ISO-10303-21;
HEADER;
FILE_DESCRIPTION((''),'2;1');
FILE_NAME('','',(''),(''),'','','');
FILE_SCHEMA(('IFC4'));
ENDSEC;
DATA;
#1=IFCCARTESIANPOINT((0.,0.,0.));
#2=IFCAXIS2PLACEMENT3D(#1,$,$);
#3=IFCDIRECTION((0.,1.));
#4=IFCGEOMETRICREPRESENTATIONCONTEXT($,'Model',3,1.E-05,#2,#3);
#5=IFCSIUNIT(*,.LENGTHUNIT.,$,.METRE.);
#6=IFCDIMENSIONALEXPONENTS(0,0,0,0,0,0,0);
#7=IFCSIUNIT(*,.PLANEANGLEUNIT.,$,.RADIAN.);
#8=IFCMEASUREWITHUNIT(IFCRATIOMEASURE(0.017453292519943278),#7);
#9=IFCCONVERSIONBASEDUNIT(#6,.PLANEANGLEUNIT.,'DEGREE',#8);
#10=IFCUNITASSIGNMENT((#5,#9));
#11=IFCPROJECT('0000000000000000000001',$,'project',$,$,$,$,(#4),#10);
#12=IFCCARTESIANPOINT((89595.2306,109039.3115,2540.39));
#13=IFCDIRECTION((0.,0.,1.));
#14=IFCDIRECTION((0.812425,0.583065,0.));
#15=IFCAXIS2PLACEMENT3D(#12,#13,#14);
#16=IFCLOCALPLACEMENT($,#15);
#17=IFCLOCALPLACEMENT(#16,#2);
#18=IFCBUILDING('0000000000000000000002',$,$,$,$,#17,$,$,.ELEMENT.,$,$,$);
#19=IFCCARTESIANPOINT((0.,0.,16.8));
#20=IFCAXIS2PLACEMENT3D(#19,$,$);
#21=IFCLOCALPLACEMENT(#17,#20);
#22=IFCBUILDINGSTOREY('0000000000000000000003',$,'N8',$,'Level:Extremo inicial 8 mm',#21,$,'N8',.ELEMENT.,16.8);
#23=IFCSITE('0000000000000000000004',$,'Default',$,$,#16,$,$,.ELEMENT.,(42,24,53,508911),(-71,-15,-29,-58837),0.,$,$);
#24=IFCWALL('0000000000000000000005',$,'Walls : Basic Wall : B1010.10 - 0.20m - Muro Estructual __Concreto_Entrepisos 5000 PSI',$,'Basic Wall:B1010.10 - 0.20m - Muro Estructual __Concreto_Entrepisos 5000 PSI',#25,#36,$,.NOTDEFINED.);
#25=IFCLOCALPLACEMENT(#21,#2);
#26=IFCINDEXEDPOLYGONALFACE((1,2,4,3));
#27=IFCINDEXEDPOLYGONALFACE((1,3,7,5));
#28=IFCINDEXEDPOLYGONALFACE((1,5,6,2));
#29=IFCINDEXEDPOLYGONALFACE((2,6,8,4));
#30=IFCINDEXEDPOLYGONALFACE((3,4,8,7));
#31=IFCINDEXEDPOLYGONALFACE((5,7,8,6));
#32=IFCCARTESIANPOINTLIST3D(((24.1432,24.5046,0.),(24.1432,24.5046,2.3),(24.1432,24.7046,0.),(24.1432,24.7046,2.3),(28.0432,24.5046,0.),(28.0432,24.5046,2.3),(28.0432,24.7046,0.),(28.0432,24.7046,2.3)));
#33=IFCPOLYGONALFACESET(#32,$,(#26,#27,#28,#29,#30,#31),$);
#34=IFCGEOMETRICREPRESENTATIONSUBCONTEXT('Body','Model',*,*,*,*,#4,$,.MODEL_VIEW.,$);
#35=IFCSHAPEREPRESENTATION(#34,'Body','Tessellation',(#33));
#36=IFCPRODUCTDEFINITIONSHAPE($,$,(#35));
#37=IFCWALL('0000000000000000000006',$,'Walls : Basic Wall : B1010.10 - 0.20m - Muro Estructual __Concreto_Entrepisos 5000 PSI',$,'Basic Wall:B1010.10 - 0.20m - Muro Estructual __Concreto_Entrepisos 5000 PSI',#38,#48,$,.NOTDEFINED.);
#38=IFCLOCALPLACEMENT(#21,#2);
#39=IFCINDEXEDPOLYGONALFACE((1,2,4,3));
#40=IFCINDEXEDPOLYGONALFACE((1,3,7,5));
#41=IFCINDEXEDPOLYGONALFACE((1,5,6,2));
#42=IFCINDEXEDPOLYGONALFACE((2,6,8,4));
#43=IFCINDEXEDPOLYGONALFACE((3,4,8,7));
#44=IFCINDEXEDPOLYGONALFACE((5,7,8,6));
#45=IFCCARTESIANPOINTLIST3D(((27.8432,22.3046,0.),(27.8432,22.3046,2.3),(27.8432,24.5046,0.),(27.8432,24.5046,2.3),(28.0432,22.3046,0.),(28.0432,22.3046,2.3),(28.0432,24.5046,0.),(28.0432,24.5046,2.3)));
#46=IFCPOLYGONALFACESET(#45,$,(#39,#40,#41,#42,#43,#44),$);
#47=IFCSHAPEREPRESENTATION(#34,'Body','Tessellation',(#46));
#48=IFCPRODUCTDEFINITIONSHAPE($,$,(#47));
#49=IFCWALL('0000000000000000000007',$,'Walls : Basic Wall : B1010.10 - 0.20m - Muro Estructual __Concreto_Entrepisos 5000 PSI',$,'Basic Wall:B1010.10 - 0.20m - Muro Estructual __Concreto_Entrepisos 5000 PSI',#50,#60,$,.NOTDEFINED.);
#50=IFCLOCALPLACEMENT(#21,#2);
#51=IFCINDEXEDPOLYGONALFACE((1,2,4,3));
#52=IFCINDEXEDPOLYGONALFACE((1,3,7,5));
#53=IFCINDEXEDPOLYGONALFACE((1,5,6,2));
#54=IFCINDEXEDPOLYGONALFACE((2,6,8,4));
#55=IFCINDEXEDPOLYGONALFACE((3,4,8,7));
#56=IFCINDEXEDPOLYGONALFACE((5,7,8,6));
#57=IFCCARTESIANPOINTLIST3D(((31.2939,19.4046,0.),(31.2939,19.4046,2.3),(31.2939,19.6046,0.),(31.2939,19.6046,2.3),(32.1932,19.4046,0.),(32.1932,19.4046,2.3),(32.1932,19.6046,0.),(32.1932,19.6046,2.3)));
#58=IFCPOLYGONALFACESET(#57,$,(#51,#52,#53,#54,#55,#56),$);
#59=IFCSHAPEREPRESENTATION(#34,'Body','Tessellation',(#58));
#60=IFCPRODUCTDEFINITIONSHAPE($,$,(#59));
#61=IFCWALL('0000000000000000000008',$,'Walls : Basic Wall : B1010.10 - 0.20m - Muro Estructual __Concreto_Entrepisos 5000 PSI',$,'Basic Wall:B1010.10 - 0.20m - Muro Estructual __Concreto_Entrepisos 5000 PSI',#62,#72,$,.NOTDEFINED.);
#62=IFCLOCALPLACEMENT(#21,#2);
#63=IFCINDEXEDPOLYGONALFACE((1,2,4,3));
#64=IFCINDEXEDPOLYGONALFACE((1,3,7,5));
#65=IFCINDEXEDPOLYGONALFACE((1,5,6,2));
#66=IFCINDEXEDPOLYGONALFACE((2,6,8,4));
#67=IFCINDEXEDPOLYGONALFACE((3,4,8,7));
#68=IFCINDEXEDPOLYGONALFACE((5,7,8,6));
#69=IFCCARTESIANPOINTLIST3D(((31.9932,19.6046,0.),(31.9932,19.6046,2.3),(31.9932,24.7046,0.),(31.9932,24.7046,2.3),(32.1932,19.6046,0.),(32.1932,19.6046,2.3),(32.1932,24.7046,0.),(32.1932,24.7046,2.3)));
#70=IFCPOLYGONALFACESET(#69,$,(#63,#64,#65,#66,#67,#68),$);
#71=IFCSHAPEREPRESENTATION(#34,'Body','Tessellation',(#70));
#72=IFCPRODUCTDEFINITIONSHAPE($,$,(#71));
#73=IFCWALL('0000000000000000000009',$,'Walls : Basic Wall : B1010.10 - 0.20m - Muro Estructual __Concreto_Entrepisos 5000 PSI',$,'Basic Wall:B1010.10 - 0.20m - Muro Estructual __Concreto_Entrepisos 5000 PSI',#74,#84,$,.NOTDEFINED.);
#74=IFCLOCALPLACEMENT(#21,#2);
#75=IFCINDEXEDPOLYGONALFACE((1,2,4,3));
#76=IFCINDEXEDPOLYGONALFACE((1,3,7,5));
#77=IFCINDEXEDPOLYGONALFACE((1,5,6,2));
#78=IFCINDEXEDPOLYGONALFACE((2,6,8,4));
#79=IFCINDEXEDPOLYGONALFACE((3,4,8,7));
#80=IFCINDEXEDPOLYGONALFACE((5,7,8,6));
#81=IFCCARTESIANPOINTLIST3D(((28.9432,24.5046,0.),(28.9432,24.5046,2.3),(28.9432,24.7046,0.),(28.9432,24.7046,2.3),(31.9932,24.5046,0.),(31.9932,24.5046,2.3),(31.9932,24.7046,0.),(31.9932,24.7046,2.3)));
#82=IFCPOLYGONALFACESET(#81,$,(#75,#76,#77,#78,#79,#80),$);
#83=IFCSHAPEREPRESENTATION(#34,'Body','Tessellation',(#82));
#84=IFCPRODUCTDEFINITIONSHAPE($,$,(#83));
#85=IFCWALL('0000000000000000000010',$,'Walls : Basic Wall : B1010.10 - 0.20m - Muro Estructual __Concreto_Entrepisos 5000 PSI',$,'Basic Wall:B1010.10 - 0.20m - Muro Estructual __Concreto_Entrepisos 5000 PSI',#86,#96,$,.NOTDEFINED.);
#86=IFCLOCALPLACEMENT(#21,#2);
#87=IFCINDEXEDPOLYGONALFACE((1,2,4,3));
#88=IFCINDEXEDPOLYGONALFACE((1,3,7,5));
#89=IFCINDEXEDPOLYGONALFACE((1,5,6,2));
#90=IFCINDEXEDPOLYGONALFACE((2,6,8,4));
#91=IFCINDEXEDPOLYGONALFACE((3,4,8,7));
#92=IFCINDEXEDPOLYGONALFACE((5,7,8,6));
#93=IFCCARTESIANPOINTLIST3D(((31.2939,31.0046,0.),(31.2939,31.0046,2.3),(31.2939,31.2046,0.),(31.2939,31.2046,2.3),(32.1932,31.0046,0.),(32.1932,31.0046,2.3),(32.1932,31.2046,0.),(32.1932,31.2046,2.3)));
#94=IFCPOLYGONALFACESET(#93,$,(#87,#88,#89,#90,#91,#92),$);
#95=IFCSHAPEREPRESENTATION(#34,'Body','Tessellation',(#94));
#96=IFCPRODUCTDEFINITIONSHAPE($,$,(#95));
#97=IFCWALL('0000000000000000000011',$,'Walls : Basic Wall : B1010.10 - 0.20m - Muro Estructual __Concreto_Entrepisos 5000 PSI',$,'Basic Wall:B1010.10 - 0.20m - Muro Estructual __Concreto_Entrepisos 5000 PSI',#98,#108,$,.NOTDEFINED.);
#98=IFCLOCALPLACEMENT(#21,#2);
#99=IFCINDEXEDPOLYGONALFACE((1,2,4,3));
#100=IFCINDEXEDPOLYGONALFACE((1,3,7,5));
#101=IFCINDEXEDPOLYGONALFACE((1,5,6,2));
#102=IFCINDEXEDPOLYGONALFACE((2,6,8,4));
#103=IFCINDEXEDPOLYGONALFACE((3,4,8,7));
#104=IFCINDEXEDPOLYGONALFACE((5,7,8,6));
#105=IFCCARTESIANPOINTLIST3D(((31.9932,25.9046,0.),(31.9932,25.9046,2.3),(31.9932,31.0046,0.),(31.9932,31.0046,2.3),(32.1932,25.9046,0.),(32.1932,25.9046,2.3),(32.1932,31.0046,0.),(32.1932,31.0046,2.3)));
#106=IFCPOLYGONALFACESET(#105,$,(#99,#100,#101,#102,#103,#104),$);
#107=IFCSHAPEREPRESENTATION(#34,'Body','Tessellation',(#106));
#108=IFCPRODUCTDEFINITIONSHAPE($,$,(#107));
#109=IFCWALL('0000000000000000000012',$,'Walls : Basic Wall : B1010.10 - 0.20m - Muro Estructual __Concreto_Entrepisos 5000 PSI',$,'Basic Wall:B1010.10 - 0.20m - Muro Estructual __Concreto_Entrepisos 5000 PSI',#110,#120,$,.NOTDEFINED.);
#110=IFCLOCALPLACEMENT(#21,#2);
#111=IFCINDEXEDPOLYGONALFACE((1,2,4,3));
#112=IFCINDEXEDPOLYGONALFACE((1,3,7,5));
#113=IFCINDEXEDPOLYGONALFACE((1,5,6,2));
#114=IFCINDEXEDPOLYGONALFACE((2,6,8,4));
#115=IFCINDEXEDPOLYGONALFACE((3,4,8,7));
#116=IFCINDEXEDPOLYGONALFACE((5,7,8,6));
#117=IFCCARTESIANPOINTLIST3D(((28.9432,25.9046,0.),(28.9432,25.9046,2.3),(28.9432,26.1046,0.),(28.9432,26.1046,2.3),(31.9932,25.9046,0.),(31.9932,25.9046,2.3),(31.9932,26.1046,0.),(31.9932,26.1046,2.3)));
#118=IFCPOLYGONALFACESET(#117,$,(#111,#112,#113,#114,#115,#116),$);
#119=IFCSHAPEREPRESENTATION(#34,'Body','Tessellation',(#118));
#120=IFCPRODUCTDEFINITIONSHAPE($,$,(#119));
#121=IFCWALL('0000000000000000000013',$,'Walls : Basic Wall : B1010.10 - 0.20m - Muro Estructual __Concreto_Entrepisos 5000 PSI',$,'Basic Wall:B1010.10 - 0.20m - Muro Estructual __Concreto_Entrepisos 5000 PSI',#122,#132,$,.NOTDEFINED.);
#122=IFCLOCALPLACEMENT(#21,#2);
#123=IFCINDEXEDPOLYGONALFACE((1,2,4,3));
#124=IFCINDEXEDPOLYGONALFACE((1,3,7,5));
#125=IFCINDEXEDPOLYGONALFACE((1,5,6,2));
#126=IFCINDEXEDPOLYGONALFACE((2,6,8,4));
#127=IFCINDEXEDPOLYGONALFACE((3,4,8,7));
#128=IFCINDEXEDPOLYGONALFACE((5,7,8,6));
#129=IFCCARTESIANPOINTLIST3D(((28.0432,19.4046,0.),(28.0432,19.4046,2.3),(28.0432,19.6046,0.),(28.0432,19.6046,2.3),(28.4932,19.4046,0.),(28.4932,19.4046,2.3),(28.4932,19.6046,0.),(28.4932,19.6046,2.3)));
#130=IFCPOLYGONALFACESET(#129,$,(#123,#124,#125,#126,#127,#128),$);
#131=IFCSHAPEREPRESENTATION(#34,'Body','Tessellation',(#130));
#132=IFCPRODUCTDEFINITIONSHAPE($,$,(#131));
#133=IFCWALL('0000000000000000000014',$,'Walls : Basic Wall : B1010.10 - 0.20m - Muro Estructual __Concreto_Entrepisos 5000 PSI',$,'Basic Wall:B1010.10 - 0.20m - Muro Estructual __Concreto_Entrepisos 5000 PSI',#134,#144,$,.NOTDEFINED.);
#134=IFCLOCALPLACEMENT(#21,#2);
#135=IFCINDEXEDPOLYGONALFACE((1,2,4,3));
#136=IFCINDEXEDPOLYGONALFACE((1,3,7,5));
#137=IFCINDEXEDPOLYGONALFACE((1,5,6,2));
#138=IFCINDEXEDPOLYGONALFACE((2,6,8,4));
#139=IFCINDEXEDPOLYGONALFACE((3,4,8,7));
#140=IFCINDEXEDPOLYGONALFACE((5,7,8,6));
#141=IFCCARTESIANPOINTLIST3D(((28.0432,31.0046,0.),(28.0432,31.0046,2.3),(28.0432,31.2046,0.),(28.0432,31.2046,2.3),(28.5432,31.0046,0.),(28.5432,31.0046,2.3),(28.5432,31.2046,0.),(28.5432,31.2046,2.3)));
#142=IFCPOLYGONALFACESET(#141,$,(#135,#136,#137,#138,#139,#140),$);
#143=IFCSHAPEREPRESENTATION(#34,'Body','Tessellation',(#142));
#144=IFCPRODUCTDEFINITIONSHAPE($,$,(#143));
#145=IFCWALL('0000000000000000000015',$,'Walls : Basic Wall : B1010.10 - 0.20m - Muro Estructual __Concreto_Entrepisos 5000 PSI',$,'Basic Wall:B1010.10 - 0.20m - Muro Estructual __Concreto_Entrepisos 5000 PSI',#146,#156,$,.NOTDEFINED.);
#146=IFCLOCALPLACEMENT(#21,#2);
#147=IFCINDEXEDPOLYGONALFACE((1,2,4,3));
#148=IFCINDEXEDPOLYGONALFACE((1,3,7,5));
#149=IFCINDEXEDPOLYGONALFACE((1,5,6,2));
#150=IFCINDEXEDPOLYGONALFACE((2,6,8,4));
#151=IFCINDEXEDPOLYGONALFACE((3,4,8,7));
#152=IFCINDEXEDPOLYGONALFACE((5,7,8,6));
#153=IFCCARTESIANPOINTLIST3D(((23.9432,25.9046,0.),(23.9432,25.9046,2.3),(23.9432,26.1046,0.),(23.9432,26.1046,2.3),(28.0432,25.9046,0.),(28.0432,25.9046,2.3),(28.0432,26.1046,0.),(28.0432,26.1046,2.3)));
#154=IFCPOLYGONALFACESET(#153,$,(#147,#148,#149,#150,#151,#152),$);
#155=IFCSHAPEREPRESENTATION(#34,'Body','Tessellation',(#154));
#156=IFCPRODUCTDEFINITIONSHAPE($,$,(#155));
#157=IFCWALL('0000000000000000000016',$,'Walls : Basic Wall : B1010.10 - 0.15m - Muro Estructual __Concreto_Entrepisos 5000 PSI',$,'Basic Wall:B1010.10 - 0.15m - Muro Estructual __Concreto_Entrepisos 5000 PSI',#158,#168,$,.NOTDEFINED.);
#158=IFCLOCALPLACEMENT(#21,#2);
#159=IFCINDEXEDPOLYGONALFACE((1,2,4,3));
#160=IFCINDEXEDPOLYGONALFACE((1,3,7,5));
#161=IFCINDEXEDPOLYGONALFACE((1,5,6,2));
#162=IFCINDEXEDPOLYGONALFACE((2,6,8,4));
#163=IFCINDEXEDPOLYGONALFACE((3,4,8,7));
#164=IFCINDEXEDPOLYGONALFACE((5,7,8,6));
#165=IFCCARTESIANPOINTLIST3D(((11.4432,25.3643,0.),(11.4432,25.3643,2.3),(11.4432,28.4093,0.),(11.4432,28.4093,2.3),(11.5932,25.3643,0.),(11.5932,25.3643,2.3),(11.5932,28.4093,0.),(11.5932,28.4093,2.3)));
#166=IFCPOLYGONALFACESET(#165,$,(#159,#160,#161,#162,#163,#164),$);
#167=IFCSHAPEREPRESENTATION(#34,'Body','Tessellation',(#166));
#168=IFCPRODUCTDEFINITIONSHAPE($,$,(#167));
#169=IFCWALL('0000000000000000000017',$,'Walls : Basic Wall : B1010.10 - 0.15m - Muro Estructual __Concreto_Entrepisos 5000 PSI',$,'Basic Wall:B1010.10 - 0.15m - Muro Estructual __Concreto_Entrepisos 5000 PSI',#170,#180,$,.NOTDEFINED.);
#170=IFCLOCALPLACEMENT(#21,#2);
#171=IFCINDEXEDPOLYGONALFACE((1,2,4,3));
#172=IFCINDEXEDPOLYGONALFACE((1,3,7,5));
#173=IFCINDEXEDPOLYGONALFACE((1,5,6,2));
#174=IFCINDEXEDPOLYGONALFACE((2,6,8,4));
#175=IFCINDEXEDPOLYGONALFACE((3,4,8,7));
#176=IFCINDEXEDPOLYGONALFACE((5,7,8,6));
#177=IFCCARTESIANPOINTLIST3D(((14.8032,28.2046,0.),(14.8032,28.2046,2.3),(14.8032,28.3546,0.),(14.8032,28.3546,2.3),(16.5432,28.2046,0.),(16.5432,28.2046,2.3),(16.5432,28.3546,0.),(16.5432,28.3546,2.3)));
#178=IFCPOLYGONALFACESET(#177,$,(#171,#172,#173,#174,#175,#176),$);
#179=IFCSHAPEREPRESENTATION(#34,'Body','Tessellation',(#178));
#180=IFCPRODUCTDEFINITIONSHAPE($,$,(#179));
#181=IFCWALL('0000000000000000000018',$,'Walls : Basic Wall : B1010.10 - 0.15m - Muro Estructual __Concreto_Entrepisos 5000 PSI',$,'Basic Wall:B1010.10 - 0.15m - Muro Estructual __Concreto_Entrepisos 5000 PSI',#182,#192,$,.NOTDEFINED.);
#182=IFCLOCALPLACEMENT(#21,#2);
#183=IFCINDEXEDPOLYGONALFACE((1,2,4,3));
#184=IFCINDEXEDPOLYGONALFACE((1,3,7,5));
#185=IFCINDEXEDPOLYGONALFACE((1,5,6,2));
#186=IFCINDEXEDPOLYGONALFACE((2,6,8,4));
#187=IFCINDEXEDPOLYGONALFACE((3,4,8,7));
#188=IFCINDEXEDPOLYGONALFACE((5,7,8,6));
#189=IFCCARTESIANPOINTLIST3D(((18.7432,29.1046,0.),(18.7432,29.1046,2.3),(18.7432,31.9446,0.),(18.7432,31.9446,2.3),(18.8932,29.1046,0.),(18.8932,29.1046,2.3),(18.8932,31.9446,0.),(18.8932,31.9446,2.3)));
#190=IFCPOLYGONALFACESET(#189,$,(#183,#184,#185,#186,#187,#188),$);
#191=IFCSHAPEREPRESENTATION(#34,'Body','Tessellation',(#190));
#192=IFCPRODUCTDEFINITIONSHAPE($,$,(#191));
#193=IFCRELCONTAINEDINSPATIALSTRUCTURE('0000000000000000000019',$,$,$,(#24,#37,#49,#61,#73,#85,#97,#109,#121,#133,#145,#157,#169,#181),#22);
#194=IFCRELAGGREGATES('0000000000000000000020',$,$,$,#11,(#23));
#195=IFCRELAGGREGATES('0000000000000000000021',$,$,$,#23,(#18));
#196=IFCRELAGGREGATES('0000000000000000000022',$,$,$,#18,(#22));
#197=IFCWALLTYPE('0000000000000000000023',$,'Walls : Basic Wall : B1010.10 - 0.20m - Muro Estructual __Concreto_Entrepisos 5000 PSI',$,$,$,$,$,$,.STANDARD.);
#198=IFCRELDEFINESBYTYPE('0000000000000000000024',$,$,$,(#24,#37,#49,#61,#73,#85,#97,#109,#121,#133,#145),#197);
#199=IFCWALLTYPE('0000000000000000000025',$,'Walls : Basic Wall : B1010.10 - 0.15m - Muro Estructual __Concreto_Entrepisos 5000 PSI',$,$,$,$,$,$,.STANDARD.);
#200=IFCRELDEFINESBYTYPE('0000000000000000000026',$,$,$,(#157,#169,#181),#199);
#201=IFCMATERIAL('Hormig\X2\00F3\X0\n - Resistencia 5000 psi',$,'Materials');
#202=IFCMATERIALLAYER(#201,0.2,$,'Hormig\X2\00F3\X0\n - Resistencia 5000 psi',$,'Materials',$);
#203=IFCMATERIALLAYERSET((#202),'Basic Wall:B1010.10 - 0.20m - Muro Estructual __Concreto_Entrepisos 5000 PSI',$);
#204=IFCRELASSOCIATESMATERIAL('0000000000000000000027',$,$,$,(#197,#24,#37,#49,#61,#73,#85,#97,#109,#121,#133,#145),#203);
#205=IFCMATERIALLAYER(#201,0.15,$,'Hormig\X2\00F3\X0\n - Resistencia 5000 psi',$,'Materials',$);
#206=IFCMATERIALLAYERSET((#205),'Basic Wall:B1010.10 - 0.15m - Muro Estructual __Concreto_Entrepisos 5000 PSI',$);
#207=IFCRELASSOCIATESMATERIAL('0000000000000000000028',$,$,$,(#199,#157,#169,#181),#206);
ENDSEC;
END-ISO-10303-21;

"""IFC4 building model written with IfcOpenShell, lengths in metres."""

from ifc_helpers import new_model, entity, si_unit, converted_unit, direction, frame, frame_2d, origin, place, context, subcontext, project, spatial, rectangle, extrude, material, layer, layer_set, layer_usage, type_object, element, save


model = new_model("IFC4")

# Units and contexts
model_context = context("Model", 3, precision=1e-05, world=origin(), true_north=direction((0.0, 1.0)))
body_context = subcontext(model_context, "Body", "Model", "MODEL_VIEW")
ifc_project = project(units=[si_unit("LENGTHUNIT", "METRE"), converted_unit("PLANEANGLEUNIT", "DEGREE", entity("IfcRatioMeasure", 0.017453292519943278), si_unit("PLANEANGLEUNIT", "RADIAN"), dimensions=[0, 0, 0, 0, 0, 0, 0])], contexts=[model_context])

# Site, building, storey
site_placement = place(None, frame((89595.2306, 109039.3115, 2540.39), z_axis=(0.0, 0.0, 1.0), x_axis=(0.812425, 0.583065, 0.0)))
site = spatial("IfcSite", under=ifc_project, at=site_placement, Name="Default", CompositionType="ELEMENT", RefLatitude=(42, 24, 53, 508911), RefLongitude=(-71, -15, -29, -58837), RefElevation=0.0)
building_placement = place(site_placement, origin())
building = spatial("IfcBuilding", under=site, at=building_placement, CompositionType="ELEMENT")
storey_placement = place(building_placement, frame((0.0, 0.0, 16.8)))
storey = spatial("IfcBuildingStorey", under=building, at=storey_placement, Name="N8", ObjectType="Level:Extremo inicial 8 mm", LongName="N8", CompositionType="ELEMENT", Elevation=16.8)

# Walls
ifc_material_1 = material(Name="Hormigón - Resistencia 5000 psi", Category="Materials")
ifc_layer_1 = layer(ifc_material_1, 0.2, Name="Hormigón - Resistencia 5000 psi", Category="Materials")
ifc_layer_set_1 = layer_set([ifc_layer_1], Name="Basic Wall:B1010.10 - 0.20m - Muro Estructual __Concreto_Entrepisos 5000 PSI")
wall_type_1 = type_object("IfcWallType", Name="Walls : Basic Wall : B1010.10 - 0.20m - Muro Estructual __Concreto_Entrepisos 5000 PSI", PredefinedType="STANDARD", material=ifc_layer_set_1)
ifc_layer_usage_1 = layer_usage(ifc_layer_set_1, "AXIS2", "NEGATIVE", 0.1)
wall_1_placement = place(storey_placement, frame((24.1432, 24.6046, 0.0)))
element("IfcWall", 1, at=wall_1_placement, inside=storey, type_object=wall_type_1, material=ifc_layer_usage_1, Name="Walls : Basic Wall : B1010.10 - 0.20m - Muro Estructual __Concreto_Entrepisos 5000 PSI", ObjectType="Basic Wall:B1010.10 - 0.20m - Muro Estructual __Concreto_Entrepisos 5000 PSI", PredefinedType="NOTDEFINED", context=body_context, shape_type="SweptSolid", body=[
    extrude(rectangle(XDim=3.9, YDim=0.2, at=frame_2d((1.95, 0.0), x_axis=(-1.0, 0.0))), origin(), (0.0, 0.0, 1.0), 2.3),
])
ifc_layer_usage_2 = layer_usage(ifc_layer_set_1, "AXIS2", "NEGATIVE", 0.1)
wall_2_placement = place(storey_placement, frame((27.9432, 24.5046, 0.0), z_axis=(0.0, 0.0, 1.0), x_axis=(0.0, -1.0, 0.0)))
element("IfcWall", 2, at=wall_2_placement, inside=storey, type_object=wall_type_1, material=ifc_layer_usage_2, Name="Walls : Basic Wall : B1010.10 - 0.20m - Muro Estructual __Concreto_Entrepisos 5000 PSI", ObjectType="Basic Wall:B1010.10 - 0.20m - Muro Estructual __Concreto_Entrepisos 5000 PSI", PredefinedType="NOTDEFINED", context=body_context, shape_type="SweptSolid", body=[
    extrude(rectangle(XDim=2.2, YDim=0.2, at=frame_2d((1.1, 0.0), x_axis=(-1.0, 0.0))), origin(), (0.0, 0.0, 1.0), 2.3),
])
ifc_layer_usage_3 = layer_usage(ifc_layer_set_1, "AXIS2", "NEGATIVE", 0.1)
wall_3_placement = place(storey_placement, frame((31.2939, 19.5046, 0.0)))
element("IfcWall", 3, at=wall_3_placement, inside=storey, type_object=wall_type_1, material=ifc_layer_usage_3, Name="Walls : Basic Wall : B1010.10 - 0.20m - Muro Estructual __Concreto_Entrepisos 5000 PSI", ObjectType="Basic Wall:B1010.10 - 0.20m - Muro Estructual __Concreto_Entrepisos 5000 PSI", PredefinedType="NOTDEFINED", context=body_context, shape_type="SweptSolid", body=[
    extrude(rectangle(XDim=0.8993, YDim=0.2, at=frame_2d((0.4497, 0.0), x_axis=(-1.0, 0.0))), origin(), (0.0, 0.0, 1.0), 2.3),
])
ifc_layer_usage_4 = layer_usage(ifc_layer_set_1, "AXIS2", "NEGATIVE", 0.1)
wall_4_placement = place(storey_placement, frame((32.0932, 19.6046, 0.0), z_axis=(0.0, 0.0, 1.0), x_axis=(0.0, 1.0, 0.0)))
element("IfcWall", 4, at=wall_4_placement, inside=storey, type_object=wall_type_1, material=ifc_layer_usage_4, Name="Walls : Basic Wall : B1010.10 - 0.20m - Muro Estructual __Concreto_Entrepisos 5000 PSI", ObjectType="Basic Wall:B1010.10 - 0.20m - Muro Estructual __Concreto_Entrepisos 5000 PSI", PredefinedType="NOTDEFINED", context=body_context, shape_type="SweptSolid", body=[
    extrude(rectangle(XDim=5.1, YDim=0.2, at=frame_2d((2.55, 0.0), x_axis=(-1.0, 0.0))), origin(), (0.0, 0.0, 1.0), 2.3),
])
ifc_layer_usage_5 = layer_usage(ifc_layer_set_1, "AXIS2", "NEGATIVE", 0.1)
wall_5_placement = place(storey_placement, frame((31.9932, 24.6046, 0.0), z_axis=(0.0, 0.0, 1.0), x_axis=(-1.0, 0.0, 0.0)))
element("IfcWall", 5, at=wall_5_placement, inside=storey, type_object=wall_type_1, material=ifc_layer_usage_5, Name="Walls : Basic Wall : B1010.10 - 0.20m - Muro Estructual __Concreto_Entrepisos 5000 PSI", ObjectType="Basic Wall:B1010.10 - 0.20m - Muro Estructual __Concreto_Entrepisos 5000 PSI", PredefinedType="NOTDEFINED", context=body_context, shape_type="SweptSolid", body=[
    extrude(rectangle(XDim=3.05, YDim=0.2, at=frame_2d((1.525, 0.0), x_axis=(-1.0, 0.0))), origin(), (0.0, 0.0, 1.0), 2.3),
])
ifc_layer_usage_6 = layer_usage(ifc_layer_set_1, "AXIS2", "POSITIVE", -0.1)
wall_6_placement = place(storey_placement, frame((31.2939, 31.1046, 0.0)))
element("IfcWall", 6, at=wall_6_placement, inside=storey, type_object=wall_type_1, material=ifc_layer_usage_6, Name="Walls : Basic Wall : B1010.10 - 0.20m - Muro Estructual __Concreto_Entrepisos 5000 PSI", ObjectType="Basic Wall:B1010.10 - 0.20m - Muro Estructual __Concreto_Entrepisos 5000 PSI", PredefinedType="NOTDEFINED", context=body_context, shape_type="SweptSolid", body=[
    extrude(rectangle(XDim=0.8993, YDim=0.2, at=frame_2d((0.4497, 0.0), x_axis=(-1.0, 0.0))), origin(), (0.0, 0.0, 1.0), 2.3),
])
ifc_layer_usage_7 = layer_usage(ifc_layer_set_1, "AXIS2", "POSITIVE", -0.1)
wall_7_placement = place(storey_placement, frame((32.0932, 31.0046, 0.0), z_axis=(0.0, 0.0, 1.0), x_axis=(0.0, -1.0, 0.0)))
element("IfcWall", 7, at=wall_7_placement, inside=storey, type_object=wall_type_1, material=ifc_layer_usage_7, Name="Walls : Basic Wall : B1010.10 - 0.20m - Muro Estructual __Concreto_Entrepisos 5000 PSI", ObjectType="Basic Wall:B1010.10 - 0.20m - Muro Estructual __Concreto_Entrepisos 5000 PSI", PredefinedType="NOTDEFINED", context=body_context, shape_type="SweptSolid", body=[
    extrude(rectangle(XDim=5.1, YDim=0.2, at=frame_2d((2.55, 0.0), x_axis=(-1.0, 0.0))), origin(), (0.0, 0.0, 1.0), 2.3),
])
ifc_layer_usage_8 = layer_usage(ifc_layer_set_1, "AXIS2", "POSITIVE", -0.1)
wall_8_placement = place(storey_placement, frame((31.9932, 26.0046, 0.0), z_axis=(0.0, 0.0, 1.0), x_axis=(-1.0, 0.0, 0.0)))
element("IfcWall", 8, at=wall_8_placement, inside=storey, type_object=wall_type_1, material=ifc_layer_usage_8, Name="Walls : Basic Wall : B1010.10 - 0.20m - Muro Estructual __Concreto_Entrepisos 5000 PSI", ObjectType="Basic Wall:B1010.10 - 0.20m - Muro Estructual __Concreto_Entrepisos 5000 PSI", PredefinedType="NOTDEFINED", context=body_context, shape_type="SweptSolid", body=[
    extrude(rectangle(XDim=3.05, YDim=0.2, at=frame_2d((1.525, 0.0), x_axis=(-1.0, 0.0))), origin(), (0.0, 0.0, 1.0), 2.3),
])
ifc_layer_usage_9 = layer_usage(ifc_layer_set_1, "AXIS2", "NEGATIVE", 0.1)
wall_9_placement = place(storey_placement, frame((28.4932, 19.5046, 0.0), z_axis=(0.0, 0.0, 1.0), x_axis=(-1.0, 0.0, 0.0)))
element("IfcWall", 9, at=wall_9_placement, inside=storey, type_object=wall_type_1, material=ifc_layer_usage_9, Name="Walls : Basic Wall : B1010.10 - 0.20m - Muro Estructual __Concreto_Entrepisos 5000 PSI", ObjectType="Basic Wall:B1010.10 - 0.20m - Muro Estructual __Concreto_Entrepisos 5000 PSI", PredefinedType="NOTDEFINED", context=body_context, shape_type="SweptSolid", body=[
    extrude(rectangle(XDim=0.45, YDim=0.2, at=frame_2d((0.225, 0.0), x_axis=(-1.0, 0.0))), origin(), (0.0, 0.0, 1.0), 2.3),
])
ifc_layer_usage_10 = layer_usage(ifc_layer_set_1, "AXIS2", "NEGATIVE", 0.1)
wall_10_placement = place(storey_placement, frame((28.5432, 31.1046, 0.0), z_axis=(0.0, 0.0, 1.0), x_axis=(-1.0, 0.0, 0.0)))
element("IfcWall", 10, at=wall_10_placement, inside=storey, type_object=wall_type_1, material=ifc_layer_usage_10, Name="Walls : Basic Wall : B1010.10 - 0.20m - Muro Estructual __Concreto_Entrepisos 5000 PSI", ObjectType="Basic Wall:B1010.10 - 0.20m - Muro Estructual __Concreto_Entrepisos 5000 PSI", PredefinedType="NOTDEFINED", context=body_context, shape_type="SweptSolid", body=[
    extrude(rectangle(XDim=0.5, YDim=0.2, at=frame_2d((0.25, 0.0), x_axis=(-1.0, 0.0))), origin(), (0.0, 0.0, 1.0), 2.3),
])
ifc_layer_usage_11 = layer_usage(ifc_layer_set_1, "AXIS2", "NEGATIVE", 0.1)
wall_11_placement = place(storey_placement, frame((23.9432, 26.0046, 0.0)))
element("IfcWall", 11, at=wall_11_placement, inside=storey, type_object=wall_type_1, material=ifc_layer_usage_11, Name="Walls : Basic Wall : B1010.10 - 0.20m - Muro Estructual __Concreto_Entrepisos 5000 PSI", ObjectType="Basic Wall:B1010.10 - 0.20m - Muro Estructual __Concreto_Entrepisos 5000 PSI", PredefinedType="NOTDEFINED", context=body_context, shape_type="SweptSolid", body=[
    extrude(rectangle(XDim=4.1, YDim=0.2, at=frame_2d((2.05, 0.0), x_axis=(-1.0, 0.0))), origin(), (0.0, 0.0, 1.0), 2.3),
])
ifc_layer_2 = layer(ifc_material_1, 0.15, Name="Hormigón - Resistencia 5000 psi", Category="Materials")
ifc_layer_set_2 = layer_set([ifc_layer_2], Name="Basic Wall:B1010.10 - 0.15m - Muro Estructual __Concreto_Entrepisos 5000 PSI")
ifc_layer_usage_12 = layer_usage(ifc_layer_set_2, "AXIS2", "NEGATIVE", 0.075)
wall_type_2 = type_object("IfcWallType", Name="Walls : Basic Wall : B1010.10 - 0.15m - Muro Estructual __Concreto_Entrepisos 5000 PSI", PredefinedType="STANDARD", material=ifc_layer_set_2)
wall_12_placement = place(storey_placement, frame((11.5182, 25.3643, 0.0), z_axis=(0.0, 0.0, 1.0), x_axis=(0.0, 1.0, 0.0)))
element("IfcWall", 12, at=wall_12_placement, inside=storey, type_object=wall_type_2, material=ifc_layer_usage_12, Name="Walls : Basic Wall : B1010.10 - 0.15m - Muro Estructual __Concreto_Entrepisos 5000 PSI", ObjectType="Basic Wall:B1010.10 - 0.15m - Muro Estructual __Concreto_Entrepisos 5000 PSI", PredefinedType="NOTDEFINED", context=body_context, shape_type="SweptSolid", body=[
    extrude(rectangle(XDim=3.045, YDim=0.15, at=frame_2d((1.5225, 0.0), x_axis=(-1.0, 0.0))), origin(), (0.0, 0.0, 1.0), 2.3),
])
ifc_layer_usage_13 = layer_usage(ifc_layer_set_2, "AXIS2", "NEGATIVE", 0.075)
wall_13_placement = place(storey_placement, frame((16.5432, 28.2796, 0.0), z_axis=(0.0, 0.0, 1.0), x_axis=(-1.0, 0.0, 0.0)))
element("IfcWall", 13, at=wall_13_placement, inside=storey, type_object=wall_type_2, material=ifc_layer_usage_13, Name="Walls : Basic Wall : B1010.10 - 0.15m - Muro Estructual __Concreto_Entrepisos 5000 PSI", ObjectType="Basic Wall:B1010.10 - 0.15m - Muro Estructual __Concreto_Entrepisos 5000 PSI", PredefinedType="NOTDEFINED", context=body_context, shape_type="SweptSolid", body=[
    extrude(rectangle(XDim=1.74, YDim=0.15, at=frame_2d((0.87, 0.0), x_axis=(-1.0, 0.0))), origin(), (0.0, 0.0, 1.0), 2.3),
])
ifc_layer_usage_14 = layer_usage(ifc_layer_set_2, "AXIS2", "NEGATIVE", 0.075)
wall_14_placement = place(storey_placement, frame((18.8182, 31.9446, 0.0), z_axis=(0.0, 0.0, 1.0), x_axis=(0.0, -1.0, 0.0)))
element("IfcWall", 14, at=wall_14_placement, inside=storey, type_object=wall_type_2, material=ifc_layer_usage_14, Name="Walls : Basic Wall : B1010.10 - 0.15m - Muro Estructual __Concreto_Entrepisos 5000 PSI", ObjectType="Basic Wall:B1010.10 - 0.15m - Muro Estructual __Concreto_Entrepisos 5000 PSI", PredefinedType="NOTDEFINED", context=body_context, shape_type="SweptSolid", body=[
    extrude(rectangle(XDim=2.84, YDim=0.15, at=frame_2d((1.42, 0.0), x_axis=(-1.0, 0.0))), origin(), (0.0, 0.0, 1.0), 2.3),
])

save(model, "model.ifc")
